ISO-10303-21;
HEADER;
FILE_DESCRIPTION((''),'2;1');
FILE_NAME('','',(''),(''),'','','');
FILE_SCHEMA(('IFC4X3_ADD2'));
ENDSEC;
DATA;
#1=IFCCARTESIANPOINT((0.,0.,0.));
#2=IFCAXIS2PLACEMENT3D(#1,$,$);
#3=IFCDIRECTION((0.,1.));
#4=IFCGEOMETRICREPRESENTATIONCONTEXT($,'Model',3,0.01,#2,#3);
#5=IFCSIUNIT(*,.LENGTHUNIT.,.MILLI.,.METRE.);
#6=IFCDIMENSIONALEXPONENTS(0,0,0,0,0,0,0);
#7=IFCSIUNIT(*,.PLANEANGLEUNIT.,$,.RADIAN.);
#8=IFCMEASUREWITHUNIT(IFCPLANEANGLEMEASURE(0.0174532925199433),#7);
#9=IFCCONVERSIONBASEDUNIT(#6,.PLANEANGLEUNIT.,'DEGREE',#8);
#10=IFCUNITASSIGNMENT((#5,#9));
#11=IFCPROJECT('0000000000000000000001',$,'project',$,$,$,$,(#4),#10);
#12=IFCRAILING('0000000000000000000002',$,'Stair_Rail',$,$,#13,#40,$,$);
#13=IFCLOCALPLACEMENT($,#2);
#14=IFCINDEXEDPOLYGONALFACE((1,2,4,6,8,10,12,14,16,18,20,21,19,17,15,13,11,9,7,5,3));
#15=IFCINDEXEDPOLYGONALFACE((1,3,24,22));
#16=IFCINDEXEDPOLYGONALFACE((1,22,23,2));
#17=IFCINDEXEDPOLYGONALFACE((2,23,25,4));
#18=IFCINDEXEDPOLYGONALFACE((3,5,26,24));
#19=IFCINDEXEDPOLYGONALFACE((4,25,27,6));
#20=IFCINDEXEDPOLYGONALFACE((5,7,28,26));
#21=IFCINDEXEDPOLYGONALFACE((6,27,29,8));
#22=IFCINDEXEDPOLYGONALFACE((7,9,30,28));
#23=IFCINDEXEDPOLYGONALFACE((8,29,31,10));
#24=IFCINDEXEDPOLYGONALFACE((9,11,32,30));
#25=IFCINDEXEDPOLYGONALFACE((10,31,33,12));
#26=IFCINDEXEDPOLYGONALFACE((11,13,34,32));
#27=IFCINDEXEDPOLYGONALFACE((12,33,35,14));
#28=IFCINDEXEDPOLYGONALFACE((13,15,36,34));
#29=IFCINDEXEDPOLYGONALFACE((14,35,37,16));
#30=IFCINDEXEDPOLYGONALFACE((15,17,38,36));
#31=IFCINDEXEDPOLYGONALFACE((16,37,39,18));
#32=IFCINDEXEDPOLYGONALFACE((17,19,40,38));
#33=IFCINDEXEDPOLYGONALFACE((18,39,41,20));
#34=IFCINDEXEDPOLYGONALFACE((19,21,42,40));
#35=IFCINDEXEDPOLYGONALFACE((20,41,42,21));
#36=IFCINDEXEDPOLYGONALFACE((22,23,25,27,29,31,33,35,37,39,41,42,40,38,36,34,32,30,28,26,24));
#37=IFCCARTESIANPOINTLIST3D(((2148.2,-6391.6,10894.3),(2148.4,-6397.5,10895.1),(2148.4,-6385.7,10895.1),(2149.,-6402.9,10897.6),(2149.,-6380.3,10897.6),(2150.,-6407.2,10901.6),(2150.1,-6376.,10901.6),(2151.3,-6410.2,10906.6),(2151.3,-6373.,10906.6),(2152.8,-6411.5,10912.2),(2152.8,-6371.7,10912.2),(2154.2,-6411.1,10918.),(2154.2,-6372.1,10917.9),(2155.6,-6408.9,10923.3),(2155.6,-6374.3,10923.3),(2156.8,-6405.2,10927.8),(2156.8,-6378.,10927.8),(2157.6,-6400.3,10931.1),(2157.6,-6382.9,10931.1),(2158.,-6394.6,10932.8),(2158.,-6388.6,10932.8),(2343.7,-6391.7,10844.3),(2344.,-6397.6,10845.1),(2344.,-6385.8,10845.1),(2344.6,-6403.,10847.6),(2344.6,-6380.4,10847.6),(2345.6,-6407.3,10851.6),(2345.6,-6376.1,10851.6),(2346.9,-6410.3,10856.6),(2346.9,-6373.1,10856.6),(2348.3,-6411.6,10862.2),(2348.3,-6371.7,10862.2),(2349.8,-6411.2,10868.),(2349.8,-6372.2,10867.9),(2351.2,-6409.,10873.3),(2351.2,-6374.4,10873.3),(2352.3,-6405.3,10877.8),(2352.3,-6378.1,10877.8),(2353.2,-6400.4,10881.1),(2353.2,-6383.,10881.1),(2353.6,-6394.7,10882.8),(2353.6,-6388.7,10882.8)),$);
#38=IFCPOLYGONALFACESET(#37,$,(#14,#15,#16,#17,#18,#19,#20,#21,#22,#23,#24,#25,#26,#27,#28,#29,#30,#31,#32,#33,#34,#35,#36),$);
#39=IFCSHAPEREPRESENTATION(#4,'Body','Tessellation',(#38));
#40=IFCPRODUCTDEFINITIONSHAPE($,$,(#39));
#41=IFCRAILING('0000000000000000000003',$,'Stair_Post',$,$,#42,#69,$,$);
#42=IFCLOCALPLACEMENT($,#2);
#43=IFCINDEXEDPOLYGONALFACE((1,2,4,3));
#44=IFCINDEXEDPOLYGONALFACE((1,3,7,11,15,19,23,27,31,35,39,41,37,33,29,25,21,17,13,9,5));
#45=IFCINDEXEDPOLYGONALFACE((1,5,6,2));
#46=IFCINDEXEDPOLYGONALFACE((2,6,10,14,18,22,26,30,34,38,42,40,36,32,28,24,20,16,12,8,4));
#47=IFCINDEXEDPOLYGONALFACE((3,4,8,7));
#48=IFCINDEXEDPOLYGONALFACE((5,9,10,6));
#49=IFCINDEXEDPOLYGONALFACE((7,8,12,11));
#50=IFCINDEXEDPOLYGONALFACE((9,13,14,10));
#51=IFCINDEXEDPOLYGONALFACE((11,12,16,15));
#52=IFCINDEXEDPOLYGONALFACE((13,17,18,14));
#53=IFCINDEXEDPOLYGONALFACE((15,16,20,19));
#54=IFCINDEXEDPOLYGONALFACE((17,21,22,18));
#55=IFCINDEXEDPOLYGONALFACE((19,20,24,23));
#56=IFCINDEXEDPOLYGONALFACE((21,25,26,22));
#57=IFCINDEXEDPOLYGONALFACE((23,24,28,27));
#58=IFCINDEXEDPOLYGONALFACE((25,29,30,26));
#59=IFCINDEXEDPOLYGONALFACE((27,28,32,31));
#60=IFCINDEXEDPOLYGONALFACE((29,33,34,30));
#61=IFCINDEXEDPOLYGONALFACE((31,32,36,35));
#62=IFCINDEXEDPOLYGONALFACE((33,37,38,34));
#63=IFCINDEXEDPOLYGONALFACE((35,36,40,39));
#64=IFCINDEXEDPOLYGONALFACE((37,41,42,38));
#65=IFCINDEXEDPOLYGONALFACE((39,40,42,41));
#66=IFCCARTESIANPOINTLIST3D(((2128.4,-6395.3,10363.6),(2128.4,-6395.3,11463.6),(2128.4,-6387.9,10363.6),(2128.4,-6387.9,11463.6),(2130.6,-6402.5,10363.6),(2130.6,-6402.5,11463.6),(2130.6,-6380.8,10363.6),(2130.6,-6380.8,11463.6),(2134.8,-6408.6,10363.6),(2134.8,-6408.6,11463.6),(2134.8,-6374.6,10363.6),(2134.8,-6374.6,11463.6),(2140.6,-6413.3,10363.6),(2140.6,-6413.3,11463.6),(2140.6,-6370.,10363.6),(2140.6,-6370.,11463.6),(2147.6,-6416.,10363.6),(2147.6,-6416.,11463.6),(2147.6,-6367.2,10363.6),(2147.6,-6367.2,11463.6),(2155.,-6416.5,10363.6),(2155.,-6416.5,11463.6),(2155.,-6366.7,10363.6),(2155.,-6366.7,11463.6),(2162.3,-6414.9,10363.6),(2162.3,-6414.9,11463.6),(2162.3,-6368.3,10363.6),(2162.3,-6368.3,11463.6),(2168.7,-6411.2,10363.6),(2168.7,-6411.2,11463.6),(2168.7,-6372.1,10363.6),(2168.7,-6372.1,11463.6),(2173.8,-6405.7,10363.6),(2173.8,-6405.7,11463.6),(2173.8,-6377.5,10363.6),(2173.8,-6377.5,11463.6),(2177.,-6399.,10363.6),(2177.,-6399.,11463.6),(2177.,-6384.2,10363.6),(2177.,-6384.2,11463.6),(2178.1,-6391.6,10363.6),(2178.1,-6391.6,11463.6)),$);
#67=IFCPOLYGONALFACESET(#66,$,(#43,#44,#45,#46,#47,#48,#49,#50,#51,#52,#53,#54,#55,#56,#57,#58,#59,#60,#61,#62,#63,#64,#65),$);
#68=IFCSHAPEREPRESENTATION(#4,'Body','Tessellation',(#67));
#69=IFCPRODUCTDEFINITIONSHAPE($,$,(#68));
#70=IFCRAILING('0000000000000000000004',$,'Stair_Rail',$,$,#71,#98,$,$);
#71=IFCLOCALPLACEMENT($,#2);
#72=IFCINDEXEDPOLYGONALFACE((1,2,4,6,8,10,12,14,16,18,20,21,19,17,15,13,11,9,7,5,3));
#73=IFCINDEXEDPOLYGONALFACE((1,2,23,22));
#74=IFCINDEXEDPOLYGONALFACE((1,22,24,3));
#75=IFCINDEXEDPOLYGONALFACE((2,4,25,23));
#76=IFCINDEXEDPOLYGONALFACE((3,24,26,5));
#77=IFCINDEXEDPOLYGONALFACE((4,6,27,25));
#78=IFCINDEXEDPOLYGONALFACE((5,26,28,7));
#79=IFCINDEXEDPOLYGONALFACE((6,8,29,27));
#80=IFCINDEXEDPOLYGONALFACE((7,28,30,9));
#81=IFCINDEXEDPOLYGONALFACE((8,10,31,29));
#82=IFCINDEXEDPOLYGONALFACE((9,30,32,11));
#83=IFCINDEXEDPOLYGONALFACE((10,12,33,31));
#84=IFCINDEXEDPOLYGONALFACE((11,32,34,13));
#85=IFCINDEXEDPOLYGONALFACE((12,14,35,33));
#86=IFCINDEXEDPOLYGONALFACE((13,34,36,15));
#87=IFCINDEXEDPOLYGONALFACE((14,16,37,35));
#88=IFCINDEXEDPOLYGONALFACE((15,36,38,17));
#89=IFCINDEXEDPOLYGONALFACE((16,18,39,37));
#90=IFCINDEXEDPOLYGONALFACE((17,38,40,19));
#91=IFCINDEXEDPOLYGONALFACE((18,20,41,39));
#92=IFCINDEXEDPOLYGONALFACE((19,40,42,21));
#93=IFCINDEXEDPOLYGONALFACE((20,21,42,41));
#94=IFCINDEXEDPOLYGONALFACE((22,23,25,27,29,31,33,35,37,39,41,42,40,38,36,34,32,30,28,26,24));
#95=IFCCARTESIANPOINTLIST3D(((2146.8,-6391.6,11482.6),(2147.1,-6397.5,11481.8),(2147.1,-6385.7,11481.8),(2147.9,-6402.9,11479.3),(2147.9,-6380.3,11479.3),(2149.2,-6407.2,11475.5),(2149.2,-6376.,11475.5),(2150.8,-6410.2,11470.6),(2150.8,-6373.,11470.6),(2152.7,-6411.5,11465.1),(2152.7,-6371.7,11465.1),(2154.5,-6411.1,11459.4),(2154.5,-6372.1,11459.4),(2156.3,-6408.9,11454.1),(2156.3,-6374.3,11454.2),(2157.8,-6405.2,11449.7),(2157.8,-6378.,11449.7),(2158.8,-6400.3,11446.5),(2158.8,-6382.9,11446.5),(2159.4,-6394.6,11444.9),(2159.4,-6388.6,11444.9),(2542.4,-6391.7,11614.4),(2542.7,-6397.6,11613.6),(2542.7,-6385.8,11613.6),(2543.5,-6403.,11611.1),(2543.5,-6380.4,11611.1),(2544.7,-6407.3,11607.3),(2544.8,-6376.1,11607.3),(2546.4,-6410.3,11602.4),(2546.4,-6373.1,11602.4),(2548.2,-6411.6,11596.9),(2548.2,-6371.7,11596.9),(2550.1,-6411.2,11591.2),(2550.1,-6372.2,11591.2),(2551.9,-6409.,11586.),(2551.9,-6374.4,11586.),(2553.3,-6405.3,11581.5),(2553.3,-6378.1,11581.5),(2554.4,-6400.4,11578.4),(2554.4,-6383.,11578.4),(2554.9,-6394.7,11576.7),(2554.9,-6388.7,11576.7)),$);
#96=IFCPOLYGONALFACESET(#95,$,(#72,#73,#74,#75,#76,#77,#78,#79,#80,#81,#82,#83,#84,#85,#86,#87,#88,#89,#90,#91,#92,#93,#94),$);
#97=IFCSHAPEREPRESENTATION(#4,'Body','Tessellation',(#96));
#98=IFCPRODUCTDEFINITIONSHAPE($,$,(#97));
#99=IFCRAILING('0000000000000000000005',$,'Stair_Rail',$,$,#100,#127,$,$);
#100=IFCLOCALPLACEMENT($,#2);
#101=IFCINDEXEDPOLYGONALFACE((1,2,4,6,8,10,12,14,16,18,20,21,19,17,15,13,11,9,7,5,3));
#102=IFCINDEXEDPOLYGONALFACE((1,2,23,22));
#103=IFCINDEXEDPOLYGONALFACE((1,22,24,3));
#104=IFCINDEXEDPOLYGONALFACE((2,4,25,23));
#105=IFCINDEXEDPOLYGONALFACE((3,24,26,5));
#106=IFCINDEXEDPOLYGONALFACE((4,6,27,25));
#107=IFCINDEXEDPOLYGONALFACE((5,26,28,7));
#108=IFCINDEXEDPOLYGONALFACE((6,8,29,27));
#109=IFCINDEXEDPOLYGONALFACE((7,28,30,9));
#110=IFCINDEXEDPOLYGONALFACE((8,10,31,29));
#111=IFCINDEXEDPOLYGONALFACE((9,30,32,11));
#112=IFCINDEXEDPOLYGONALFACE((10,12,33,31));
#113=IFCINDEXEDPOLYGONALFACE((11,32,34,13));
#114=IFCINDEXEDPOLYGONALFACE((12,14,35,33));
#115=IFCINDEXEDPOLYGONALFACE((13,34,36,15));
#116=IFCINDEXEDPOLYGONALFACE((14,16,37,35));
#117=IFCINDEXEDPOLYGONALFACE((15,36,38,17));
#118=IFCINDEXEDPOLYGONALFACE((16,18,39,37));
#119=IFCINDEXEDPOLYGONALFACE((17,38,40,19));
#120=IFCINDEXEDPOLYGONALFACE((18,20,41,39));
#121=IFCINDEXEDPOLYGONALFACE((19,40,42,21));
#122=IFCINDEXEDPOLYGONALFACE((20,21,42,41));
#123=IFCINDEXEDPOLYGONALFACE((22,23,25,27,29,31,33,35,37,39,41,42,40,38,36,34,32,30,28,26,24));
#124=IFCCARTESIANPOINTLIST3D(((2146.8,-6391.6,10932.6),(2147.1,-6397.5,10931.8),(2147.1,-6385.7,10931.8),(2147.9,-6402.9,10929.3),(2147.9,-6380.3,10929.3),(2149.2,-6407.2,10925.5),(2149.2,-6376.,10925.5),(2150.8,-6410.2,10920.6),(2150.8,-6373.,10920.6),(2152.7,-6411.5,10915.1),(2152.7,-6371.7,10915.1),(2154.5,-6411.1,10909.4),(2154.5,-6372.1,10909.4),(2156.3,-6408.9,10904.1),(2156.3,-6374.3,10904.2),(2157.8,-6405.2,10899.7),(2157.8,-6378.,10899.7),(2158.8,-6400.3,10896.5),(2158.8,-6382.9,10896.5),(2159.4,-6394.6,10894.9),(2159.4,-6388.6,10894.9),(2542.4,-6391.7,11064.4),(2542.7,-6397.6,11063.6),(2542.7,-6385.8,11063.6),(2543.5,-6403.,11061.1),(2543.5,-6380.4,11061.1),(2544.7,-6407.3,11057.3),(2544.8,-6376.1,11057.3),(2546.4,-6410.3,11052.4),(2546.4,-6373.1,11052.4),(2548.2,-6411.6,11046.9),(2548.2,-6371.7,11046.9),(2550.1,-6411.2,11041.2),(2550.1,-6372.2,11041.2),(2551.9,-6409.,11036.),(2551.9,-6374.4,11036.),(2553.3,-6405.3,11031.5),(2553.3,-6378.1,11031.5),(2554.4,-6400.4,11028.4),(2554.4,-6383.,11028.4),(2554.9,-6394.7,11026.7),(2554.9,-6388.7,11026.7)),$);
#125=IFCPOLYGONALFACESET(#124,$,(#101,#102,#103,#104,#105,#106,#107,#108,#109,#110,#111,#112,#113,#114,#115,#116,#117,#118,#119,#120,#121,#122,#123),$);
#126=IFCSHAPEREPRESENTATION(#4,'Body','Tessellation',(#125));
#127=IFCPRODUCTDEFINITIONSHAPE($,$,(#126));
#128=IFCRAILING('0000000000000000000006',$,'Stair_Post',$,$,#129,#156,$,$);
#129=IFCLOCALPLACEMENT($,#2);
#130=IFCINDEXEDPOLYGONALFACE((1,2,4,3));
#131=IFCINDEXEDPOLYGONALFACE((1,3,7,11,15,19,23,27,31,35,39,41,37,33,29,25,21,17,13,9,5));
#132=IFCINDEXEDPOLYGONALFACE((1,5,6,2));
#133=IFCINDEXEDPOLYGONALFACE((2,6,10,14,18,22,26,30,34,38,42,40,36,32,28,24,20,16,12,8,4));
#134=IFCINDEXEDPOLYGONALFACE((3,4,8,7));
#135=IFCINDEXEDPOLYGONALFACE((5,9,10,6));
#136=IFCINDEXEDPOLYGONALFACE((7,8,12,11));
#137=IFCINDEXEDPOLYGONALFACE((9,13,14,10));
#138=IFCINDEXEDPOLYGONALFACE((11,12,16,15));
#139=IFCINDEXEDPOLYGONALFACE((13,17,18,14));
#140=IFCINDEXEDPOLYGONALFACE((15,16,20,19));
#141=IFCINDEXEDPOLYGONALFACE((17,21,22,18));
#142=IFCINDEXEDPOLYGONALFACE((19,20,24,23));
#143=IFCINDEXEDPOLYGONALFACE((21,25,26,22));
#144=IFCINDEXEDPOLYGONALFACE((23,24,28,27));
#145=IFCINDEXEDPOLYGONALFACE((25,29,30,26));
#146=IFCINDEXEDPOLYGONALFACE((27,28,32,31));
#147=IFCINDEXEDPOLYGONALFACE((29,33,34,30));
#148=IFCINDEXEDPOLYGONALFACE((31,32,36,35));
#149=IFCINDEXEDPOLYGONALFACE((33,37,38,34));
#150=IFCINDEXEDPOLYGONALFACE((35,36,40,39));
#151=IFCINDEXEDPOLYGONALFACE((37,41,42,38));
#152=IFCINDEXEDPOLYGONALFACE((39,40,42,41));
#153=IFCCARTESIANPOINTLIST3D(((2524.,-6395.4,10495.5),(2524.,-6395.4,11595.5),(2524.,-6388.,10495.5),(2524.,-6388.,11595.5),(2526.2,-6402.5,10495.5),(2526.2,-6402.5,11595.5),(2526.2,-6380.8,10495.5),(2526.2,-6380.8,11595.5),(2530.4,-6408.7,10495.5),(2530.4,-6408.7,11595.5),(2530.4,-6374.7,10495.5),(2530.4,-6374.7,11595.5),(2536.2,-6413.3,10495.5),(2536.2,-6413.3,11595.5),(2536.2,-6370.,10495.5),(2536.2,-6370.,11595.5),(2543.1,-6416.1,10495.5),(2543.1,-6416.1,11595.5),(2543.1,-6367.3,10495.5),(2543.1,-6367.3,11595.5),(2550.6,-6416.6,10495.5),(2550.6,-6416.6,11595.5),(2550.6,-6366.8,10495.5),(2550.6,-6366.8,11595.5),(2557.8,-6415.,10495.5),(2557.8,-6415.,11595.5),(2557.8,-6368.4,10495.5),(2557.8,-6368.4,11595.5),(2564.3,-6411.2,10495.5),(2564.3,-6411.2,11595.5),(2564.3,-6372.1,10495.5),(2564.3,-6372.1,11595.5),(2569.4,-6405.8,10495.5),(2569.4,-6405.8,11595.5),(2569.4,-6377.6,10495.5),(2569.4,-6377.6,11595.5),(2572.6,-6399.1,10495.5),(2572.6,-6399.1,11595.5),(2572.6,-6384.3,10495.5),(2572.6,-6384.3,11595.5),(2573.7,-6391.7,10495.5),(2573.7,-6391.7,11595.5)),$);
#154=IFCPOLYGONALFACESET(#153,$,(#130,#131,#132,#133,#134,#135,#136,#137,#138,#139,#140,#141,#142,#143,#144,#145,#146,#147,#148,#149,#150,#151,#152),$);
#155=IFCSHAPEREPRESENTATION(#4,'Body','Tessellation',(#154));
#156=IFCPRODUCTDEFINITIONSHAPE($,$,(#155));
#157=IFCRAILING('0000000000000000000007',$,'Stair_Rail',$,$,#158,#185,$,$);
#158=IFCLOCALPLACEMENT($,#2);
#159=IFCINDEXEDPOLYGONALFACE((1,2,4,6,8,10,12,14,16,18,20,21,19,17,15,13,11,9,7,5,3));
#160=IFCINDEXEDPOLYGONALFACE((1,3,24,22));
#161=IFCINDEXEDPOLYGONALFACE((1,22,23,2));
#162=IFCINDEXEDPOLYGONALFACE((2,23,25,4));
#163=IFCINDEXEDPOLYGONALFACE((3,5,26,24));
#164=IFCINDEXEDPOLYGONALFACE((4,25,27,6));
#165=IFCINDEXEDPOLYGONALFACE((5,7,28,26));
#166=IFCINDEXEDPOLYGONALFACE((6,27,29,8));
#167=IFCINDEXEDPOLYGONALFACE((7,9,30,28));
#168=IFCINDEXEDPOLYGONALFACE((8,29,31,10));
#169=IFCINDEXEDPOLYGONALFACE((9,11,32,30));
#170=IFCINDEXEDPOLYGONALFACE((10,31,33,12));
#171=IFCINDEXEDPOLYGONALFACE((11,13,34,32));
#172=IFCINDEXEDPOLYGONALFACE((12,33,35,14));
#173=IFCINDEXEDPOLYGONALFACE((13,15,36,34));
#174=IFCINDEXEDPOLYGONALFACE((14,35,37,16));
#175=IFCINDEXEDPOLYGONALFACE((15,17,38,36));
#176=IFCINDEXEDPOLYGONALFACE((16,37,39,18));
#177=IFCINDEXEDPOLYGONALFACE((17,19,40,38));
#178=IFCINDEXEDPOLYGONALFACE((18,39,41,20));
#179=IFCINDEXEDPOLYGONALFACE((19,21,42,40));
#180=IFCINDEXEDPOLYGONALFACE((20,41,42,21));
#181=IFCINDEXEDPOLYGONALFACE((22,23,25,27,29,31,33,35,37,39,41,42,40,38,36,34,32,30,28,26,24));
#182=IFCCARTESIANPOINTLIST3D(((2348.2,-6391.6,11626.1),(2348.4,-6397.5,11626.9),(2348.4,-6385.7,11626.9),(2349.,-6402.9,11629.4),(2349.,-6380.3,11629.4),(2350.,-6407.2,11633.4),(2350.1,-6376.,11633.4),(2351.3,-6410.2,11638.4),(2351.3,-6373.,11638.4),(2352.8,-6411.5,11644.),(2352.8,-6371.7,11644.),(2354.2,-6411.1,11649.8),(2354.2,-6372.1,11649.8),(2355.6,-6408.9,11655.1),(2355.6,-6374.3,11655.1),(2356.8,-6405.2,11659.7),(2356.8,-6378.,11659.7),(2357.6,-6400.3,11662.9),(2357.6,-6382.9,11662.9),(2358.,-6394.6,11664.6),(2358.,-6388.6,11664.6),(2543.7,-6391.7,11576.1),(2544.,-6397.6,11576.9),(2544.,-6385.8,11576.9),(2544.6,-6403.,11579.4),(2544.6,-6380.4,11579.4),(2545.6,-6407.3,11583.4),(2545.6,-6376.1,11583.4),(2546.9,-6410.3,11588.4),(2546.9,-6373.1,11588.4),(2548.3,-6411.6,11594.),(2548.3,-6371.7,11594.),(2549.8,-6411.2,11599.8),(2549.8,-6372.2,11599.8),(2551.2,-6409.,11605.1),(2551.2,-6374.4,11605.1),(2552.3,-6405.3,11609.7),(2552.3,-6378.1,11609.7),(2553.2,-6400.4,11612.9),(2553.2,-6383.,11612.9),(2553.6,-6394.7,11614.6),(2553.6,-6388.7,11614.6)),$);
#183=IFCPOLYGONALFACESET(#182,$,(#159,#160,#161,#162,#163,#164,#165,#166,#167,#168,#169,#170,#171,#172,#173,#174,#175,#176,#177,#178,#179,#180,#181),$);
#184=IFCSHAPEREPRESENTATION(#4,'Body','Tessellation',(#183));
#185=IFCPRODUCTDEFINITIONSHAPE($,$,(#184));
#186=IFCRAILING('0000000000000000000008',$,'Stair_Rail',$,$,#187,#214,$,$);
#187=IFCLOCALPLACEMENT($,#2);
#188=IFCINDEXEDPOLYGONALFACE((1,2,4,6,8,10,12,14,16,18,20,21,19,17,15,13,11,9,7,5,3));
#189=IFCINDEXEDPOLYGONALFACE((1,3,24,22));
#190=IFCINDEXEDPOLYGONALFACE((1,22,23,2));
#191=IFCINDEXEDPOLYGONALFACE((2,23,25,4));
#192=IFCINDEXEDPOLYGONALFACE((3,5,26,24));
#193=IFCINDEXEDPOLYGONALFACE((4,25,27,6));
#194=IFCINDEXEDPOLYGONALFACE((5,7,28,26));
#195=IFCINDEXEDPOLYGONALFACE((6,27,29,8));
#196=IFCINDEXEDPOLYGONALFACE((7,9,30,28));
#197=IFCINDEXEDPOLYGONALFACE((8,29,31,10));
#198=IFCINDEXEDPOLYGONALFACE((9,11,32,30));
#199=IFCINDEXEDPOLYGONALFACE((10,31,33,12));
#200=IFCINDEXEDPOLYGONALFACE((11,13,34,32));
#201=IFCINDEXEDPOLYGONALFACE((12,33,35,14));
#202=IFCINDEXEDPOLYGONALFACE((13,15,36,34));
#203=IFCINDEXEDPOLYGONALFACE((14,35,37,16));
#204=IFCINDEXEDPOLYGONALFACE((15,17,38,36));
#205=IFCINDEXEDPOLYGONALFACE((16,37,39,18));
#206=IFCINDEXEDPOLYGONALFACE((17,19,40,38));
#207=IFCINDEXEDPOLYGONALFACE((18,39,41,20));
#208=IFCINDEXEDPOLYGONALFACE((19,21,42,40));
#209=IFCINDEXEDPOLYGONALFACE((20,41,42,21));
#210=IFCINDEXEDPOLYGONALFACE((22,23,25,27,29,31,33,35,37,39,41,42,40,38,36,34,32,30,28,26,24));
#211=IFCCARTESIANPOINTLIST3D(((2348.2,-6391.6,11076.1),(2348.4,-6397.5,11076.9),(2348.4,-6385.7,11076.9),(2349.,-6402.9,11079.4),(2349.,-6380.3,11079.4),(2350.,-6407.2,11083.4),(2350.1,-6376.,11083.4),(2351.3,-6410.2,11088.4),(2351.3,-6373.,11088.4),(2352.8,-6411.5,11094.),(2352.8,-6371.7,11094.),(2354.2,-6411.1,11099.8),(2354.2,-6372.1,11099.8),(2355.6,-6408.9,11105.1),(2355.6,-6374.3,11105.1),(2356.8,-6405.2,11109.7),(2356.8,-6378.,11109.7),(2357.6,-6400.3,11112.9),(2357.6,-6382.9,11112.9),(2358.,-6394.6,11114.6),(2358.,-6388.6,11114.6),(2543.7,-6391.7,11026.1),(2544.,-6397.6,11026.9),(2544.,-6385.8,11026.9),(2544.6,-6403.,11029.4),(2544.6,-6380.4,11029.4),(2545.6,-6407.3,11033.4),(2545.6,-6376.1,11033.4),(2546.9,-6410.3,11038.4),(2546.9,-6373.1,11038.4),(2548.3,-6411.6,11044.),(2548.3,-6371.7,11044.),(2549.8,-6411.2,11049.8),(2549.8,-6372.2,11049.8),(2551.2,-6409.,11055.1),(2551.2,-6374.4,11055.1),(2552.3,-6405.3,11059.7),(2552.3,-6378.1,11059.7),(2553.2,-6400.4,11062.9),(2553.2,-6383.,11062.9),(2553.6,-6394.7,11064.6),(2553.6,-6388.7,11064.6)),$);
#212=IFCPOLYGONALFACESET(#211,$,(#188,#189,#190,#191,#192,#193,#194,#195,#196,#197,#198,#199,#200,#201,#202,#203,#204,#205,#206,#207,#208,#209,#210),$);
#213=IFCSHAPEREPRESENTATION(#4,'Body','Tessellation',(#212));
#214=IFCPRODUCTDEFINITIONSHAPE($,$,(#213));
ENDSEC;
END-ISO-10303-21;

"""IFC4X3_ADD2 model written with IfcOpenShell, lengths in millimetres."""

from ifc_helpers import new_model, entity, si_unit, converted_unit, direction, frame, origin, context, project, circle, extrude, element, save


model = new_model("IFC4X3_ADD2")

# Units and contexts
model_context = context("Model", 3, precision=0.01, world=origin(), true_north=direction((0.0, 1.0)))
ifc_project = project(units=[si_unit("LENGTHUNIT", "METRE", prefix="MILLI"), converted_unit("PLANEANGLEUNIT", "DEGREE", entity("IfcPlaneAngleMeasure", 0.0174532925199433), si_unit("PLANEANGLEUNIT", "RADIAN"), dimensions=[0, 0, 0, 0, 0, 0, 0])], contexts=[model_context])

# Railings
element("IfcRailing", 1, Name="Stair_Rail", context=model_context, shape_type="SweptSolid", body=[
    entity("IfcSweptDiskSolid", entity("IfcPolyline", [entity("IfcCartesianPoint", [2348.7, -6391.7, 10863.6]), entity("IfcCartesianPoint", [2153.1, -6391.6, 10913.6])]), 20.0),
])
element("IfcRailing", 2, Name="Stair_Post", context=model_context, shape_type="SweptSolid", body=[
    extrude(circle(Radius=25.0), frame((2153.1, -6391.6, 10363.6)), (0.0, 0.0, 1.0), 1100.0),
])
element("IfcRailing", 3, Name="Stair_Rail", context=model_context, shape_type="SweptSolid", body=[
    entity("IfcSweptDiskSolid", entity("IfcPolyline", [entity("IfcCartesianPoint", [2153.1, -6391.6, 11463.6]), entity("IfcCartesianPoint", [2548.7, -6391.7, 11595.5])]), 20.0),
])
element("IfcRailing", 4, Name="Stair_Rail", context=model_context, shape_type="SweptSolid", body=[
    entity("IfcSweptDiskSolid", entity("IfcPolyline", [entity("IfcCartesianPoint", [2153.1, -6391.6, 10913.6]), entity("IfcCartesianPoint", [2548.7, -6391.7, 11045.5])]), 20.0),
])
element("IfcRailing", 5, Name="Stair_Post", context=model_context, shape_type="SweptSolid", body=[
    extrude(circle(Radius=25.0), frame((2548.7, -6391.7, 10495.5)), (0.0, 0.0, 1.0), 1100.0),
])
element("IfcRailing", 6, Name="Stair_Rail", context=model_context, shape_type="SweptSolid", body=[
    entity("IfcSweptDiskSolid", entity("IfcPolyline", [entity("IfcCartesianPoint", [2548.7, -6391.7, 11595.5]), entity("IfcCartesianPoint", [2353.1, -6391.6, 11645.5])]), 20.0),
])
element("IfcRailing", 7, Name="Stair_Rail", context=model_context, shape_type="SweptSolid", body=[
    entity("IfcSweptDiskSolid", entity("IfcPolyline", [entity("IfcCartesianPoint", [2548.7, -6391.7, 11045.5]), entity("IfcCartesianPoint", [2353.1, -6391.6, 11095.5])]), 20.0),
])

save(model, "model.ifc")
